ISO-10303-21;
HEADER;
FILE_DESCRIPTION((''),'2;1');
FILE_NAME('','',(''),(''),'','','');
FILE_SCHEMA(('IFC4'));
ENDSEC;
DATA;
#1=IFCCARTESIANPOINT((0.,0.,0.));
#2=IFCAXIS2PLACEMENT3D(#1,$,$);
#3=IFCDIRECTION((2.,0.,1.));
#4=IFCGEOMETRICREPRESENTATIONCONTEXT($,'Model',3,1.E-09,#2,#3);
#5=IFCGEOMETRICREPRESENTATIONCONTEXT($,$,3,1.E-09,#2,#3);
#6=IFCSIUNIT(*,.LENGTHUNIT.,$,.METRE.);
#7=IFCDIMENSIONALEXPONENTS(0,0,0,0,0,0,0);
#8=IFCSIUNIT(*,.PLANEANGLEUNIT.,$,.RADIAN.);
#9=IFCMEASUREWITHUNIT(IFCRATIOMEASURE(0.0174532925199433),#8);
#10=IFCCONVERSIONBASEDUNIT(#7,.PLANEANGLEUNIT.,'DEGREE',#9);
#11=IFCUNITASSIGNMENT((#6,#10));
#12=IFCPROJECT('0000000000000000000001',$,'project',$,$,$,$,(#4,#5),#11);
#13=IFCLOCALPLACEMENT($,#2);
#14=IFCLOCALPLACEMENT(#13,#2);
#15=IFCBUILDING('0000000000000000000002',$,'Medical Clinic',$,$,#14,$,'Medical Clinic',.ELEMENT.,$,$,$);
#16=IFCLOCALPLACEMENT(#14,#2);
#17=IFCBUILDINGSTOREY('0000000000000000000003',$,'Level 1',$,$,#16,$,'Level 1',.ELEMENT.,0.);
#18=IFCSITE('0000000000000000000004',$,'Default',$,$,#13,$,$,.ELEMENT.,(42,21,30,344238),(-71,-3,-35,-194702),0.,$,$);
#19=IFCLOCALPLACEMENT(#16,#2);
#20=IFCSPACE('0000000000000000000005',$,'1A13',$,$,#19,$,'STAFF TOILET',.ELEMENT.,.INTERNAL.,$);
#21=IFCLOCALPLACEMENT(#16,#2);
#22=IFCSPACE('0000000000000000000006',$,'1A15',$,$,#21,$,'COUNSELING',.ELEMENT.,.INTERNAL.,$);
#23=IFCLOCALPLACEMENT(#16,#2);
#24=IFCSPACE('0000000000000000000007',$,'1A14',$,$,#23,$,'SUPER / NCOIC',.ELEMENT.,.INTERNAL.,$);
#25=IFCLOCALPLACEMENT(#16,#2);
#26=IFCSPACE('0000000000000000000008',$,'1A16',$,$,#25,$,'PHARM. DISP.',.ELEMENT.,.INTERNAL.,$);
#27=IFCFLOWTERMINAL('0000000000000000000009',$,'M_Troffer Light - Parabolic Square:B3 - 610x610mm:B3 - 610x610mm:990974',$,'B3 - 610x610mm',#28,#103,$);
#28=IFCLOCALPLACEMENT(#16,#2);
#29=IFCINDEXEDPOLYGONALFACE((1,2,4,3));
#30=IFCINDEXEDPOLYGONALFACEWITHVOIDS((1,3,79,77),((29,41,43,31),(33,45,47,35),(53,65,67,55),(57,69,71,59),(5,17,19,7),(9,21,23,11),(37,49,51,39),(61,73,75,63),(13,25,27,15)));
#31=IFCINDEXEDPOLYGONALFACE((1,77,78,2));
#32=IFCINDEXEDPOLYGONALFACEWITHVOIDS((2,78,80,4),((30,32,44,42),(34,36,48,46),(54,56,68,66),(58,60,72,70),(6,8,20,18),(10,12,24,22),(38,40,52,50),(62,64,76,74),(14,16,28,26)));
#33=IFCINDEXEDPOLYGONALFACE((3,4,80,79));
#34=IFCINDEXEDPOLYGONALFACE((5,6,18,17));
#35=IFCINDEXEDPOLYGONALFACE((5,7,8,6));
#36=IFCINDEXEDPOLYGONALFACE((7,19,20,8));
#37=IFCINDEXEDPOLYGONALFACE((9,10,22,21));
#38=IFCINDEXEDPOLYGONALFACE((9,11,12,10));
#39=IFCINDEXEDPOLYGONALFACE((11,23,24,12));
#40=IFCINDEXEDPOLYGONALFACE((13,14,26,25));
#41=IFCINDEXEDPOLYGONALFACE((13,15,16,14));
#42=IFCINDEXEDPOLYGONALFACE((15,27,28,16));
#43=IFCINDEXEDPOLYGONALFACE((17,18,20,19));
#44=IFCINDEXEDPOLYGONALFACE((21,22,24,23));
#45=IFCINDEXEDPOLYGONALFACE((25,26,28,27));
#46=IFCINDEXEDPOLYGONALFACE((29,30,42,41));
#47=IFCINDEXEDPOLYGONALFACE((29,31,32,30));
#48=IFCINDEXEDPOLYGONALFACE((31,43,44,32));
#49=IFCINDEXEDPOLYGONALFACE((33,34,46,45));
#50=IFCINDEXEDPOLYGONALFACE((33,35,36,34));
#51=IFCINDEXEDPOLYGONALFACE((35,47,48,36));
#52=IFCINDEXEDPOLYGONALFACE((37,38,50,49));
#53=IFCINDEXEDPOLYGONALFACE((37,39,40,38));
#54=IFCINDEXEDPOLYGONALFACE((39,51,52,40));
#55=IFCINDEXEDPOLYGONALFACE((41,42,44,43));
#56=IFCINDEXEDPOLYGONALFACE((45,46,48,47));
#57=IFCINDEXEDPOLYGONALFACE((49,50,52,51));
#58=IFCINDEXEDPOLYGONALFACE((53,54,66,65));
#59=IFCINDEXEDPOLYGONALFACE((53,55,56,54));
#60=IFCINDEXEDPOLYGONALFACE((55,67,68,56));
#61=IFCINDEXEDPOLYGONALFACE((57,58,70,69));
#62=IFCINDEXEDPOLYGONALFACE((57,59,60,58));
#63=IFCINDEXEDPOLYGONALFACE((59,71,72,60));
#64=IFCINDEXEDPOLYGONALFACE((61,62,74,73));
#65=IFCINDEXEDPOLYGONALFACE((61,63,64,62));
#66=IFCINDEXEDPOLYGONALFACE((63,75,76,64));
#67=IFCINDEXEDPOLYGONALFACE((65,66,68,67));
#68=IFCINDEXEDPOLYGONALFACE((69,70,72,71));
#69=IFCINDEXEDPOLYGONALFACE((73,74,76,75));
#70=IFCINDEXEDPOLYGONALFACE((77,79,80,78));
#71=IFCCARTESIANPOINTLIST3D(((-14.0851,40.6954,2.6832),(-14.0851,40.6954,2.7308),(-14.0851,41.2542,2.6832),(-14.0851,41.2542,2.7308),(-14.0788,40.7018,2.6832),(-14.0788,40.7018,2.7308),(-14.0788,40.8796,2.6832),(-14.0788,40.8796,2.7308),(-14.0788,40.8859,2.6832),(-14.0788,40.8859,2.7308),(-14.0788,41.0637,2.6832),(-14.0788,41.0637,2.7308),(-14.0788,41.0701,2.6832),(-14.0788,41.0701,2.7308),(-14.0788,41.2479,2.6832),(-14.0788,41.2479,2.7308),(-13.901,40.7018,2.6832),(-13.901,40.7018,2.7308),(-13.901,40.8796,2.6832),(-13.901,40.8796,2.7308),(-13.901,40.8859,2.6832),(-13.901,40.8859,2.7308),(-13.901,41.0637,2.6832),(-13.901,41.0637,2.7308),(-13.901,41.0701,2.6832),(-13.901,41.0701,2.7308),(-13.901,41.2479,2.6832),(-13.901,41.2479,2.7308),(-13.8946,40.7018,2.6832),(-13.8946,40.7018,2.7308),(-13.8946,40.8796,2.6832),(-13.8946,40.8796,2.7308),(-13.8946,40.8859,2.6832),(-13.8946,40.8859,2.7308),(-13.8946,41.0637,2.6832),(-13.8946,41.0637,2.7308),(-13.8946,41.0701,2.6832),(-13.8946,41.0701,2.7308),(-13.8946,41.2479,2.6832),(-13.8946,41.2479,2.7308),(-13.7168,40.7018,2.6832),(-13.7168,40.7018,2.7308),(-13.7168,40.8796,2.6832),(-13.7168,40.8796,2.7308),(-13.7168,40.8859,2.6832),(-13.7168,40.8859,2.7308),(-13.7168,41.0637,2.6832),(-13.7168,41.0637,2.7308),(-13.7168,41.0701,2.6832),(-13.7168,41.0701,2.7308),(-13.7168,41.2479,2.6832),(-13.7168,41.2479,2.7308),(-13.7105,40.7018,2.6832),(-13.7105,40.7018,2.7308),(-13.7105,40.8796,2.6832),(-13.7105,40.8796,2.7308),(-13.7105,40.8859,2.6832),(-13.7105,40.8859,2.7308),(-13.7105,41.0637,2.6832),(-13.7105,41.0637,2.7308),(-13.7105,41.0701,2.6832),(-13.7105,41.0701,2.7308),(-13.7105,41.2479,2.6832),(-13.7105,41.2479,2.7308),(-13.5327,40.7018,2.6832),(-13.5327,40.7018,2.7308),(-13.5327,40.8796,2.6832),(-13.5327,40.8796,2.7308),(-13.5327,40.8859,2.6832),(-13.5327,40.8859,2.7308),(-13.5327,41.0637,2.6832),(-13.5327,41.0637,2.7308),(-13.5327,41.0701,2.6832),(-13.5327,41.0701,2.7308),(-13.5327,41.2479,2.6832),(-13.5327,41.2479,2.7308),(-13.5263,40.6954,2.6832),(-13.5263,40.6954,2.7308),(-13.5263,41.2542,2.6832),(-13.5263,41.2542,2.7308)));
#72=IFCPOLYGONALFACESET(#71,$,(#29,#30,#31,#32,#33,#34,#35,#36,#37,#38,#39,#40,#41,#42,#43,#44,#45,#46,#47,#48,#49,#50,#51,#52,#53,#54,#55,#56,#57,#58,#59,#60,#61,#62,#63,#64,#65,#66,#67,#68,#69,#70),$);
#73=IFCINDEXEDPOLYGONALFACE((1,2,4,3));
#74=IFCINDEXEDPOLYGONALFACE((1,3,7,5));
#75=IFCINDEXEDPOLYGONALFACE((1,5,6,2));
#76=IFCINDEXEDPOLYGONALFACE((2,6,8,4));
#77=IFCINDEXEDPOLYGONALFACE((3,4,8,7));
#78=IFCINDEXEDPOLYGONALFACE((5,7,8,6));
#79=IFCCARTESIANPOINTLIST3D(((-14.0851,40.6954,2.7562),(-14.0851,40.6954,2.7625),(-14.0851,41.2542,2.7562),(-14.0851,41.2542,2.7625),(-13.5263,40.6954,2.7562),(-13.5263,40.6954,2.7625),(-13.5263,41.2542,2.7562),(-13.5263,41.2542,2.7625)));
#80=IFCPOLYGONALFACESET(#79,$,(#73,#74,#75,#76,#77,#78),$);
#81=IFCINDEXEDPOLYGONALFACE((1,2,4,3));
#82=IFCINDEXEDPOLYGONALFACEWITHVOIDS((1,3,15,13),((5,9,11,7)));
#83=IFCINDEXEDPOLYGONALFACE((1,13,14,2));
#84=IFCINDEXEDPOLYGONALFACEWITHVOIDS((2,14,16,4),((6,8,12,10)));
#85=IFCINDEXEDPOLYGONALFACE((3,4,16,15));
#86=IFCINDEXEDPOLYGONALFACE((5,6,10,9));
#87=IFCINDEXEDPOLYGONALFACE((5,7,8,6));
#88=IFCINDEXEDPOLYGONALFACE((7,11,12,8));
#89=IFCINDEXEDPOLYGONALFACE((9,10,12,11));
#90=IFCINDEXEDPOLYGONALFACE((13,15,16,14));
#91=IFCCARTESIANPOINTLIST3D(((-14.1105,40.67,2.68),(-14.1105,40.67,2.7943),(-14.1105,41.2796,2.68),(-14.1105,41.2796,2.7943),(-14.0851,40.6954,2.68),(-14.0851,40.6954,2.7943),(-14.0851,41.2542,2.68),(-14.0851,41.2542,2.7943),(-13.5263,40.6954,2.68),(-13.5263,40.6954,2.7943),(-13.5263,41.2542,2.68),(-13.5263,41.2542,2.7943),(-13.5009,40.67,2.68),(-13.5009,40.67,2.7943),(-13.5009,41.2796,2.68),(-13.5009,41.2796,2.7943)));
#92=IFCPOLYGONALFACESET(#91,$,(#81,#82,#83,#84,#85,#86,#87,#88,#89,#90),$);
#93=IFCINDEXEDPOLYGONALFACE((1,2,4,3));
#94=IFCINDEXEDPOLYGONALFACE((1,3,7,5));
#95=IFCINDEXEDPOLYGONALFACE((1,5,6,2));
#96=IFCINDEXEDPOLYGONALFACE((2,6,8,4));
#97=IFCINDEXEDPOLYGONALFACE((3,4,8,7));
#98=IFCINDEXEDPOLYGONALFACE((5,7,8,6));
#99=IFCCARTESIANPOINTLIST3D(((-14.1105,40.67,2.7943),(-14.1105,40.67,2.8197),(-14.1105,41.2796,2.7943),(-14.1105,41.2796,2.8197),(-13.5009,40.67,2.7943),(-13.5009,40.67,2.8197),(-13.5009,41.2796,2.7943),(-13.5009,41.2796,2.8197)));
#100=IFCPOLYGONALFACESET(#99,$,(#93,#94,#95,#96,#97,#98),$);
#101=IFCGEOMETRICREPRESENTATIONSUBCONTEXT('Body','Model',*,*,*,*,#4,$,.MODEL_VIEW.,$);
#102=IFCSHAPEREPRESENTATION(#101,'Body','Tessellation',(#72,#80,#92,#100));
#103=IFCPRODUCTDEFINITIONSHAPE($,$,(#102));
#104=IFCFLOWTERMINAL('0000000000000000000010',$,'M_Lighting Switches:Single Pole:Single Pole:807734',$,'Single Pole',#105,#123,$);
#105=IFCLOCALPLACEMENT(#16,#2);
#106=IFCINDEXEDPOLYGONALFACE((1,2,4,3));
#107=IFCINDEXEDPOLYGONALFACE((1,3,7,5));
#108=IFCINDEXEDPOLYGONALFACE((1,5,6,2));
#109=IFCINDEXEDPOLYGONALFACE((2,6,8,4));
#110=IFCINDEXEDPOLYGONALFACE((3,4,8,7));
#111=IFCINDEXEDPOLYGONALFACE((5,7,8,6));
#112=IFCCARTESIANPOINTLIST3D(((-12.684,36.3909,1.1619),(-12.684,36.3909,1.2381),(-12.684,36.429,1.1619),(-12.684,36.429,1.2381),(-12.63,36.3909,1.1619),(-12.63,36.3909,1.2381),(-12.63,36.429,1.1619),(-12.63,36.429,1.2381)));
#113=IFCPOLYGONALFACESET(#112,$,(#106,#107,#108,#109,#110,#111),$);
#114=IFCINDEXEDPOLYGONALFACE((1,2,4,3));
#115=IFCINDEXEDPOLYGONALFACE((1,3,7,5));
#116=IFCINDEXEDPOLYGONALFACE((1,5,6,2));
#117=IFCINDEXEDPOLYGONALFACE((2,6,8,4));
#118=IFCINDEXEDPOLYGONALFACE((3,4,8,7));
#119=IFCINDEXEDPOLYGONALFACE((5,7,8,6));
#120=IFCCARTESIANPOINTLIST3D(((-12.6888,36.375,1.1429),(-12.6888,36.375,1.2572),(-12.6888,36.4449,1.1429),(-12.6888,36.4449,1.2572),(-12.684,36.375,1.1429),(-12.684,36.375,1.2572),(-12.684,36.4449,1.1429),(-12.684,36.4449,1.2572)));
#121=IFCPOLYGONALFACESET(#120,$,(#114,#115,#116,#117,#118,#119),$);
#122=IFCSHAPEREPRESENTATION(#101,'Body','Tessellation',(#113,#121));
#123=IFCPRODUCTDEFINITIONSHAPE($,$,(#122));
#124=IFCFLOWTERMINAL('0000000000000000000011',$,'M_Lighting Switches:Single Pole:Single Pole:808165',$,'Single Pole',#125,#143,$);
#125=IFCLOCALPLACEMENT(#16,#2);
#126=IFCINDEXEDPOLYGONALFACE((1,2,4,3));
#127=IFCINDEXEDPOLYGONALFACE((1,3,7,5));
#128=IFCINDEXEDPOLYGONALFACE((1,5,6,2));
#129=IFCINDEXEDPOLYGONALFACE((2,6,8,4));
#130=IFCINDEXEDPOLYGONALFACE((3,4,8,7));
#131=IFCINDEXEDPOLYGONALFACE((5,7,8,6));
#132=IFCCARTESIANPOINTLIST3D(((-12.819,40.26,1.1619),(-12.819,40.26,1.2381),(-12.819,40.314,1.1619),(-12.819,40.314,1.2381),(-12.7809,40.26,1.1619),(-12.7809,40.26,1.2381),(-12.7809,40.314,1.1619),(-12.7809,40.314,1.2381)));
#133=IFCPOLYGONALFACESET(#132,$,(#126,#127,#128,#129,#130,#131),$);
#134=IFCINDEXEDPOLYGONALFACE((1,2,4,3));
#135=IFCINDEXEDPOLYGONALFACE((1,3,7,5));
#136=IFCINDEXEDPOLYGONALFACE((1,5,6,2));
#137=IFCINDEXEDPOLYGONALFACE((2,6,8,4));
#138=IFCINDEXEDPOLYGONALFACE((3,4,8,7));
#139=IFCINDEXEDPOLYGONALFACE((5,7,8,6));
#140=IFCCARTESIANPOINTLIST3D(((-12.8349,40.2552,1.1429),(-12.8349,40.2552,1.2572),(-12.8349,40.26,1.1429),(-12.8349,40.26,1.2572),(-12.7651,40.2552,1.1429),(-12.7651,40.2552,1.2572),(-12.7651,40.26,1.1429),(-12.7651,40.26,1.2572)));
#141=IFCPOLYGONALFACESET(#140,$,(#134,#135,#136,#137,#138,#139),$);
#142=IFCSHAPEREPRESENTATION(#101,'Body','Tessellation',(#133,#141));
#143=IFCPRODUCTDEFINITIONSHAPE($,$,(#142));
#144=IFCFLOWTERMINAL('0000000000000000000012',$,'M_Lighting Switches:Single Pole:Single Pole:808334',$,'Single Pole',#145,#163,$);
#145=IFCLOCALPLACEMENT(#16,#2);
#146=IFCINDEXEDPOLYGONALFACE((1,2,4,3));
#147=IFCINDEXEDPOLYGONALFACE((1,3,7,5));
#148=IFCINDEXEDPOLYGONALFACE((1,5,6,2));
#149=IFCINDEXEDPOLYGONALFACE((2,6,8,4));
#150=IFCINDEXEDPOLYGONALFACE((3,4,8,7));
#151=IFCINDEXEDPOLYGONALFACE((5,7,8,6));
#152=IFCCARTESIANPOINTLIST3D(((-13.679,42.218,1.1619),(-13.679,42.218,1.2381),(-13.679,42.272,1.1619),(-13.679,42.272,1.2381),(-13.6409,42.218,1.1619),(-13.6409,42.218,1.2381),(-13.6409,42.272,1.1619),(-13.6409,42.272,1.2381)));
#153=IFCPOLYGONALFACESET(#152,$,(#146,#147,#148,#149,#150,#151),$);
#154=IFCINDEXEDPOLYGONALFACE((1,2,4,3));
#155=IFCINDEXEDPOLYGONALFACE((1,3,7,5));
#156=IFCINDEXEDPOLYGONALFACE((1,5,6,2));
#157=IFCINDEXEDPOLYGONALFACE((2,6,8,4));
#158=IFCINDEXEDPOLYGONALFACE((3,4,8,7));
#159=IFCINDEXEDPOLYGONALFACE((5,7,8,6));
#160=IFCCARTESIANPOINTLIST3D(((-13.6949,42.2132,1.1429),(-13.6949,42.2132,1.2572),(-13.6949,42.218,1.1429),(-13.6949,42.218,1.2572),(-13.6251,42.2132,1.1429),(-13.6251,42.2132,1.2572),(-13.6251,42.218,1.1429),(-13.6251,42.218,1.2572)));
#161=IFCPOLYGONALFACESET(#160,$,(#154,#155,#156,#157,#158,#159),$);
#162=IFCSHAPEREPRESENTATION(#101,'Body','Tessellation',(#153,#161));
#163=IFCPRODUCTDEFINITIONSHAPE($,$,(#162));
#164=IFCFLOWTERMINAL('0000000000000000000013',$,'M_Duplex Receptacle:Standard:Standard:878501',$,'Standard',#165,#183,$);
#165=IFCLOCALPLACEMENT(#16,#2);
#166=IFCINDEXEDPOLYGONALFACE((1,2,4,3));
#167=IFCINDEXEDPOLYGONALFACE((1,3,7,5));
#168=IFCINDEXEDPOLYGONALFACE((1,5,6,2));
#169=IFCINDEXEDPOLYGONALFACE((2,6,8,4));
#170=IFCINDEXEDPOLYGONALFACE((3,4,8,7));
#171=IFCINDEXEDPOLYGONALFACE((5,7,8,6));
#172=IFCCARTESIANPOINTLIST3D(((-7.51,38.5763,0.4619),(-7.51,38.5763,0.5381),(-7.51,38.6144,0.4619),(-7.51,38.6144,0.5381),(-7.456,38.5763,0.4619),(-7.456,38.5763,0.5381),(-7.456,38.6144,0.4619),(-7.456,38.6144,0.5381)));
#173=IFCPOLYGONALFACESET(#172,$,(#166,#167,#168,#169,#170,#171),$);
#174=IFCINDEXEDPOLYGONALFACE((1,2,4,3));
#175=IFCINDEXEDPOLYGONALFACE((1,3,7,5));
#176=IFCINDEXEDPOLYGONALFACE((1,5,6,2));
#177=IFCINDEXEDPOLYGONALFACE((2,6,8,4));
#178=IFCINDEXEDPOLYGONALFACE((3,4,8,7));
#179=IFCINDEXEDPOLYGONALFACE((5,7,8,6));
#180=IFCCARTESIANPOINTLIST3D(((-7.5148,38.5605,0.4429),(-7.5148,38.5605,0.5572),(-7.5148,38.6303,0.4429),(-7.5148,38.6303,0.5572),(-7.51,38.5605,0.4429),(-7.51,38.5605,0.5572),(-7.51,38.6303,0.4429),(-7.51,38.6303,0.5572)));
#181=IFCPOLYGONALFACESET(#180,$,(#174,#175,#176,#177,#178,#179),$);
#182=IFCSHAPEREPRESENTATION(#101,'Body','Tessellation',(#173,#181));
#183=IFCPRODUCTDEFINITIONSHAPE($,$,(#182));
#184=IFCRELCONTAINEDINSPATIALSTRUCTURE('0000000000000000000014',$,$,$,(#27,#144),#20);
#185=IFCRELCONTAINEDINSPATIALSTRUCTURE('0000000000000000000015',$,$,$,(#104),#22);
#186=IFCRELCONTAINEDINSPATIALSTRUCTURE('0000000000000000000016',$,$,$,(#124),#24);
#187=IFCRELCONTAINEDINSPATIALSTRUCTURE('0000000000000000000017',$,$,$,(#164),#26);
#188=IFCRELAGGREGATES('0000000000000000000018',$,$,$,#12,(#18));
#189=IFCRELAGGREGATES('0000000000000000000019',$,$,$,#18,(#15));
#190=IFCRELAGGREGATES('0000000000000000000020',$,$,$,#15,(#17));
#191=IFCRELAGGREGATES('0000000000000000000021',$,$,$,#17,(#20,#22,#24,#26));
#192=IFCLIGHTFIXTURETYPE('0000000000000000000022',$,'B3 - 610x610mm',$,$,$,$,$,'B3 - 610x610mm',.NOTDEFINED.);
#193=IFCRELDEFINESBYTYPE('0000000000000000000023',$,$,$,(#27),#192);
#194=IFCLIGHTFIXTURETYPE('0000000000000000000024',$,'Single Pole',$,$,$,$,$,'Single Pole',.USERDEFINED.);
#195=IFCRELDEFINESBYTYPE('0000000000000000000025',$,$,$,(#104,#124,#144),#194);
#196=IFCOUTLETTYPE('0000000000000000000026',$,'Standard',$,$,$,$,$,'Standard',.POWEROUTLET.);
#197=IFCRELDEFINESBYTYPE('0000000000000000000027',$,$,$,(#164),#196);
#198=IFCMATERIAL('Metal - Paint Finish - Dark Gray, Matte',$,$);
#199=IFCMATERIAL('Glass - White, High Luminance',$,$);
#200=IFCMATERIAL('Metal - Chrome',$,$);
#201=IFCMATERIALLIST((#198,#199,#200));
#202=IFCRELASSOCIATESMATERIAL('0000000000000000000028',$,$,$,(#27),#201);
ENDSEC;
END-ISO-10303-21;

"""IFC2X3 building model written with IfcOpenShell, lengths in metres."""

from ifc_helpers import new_model, entity, si_unit, converted_unit, direction, frame, frame_2d, origin, origin_2d_with_axis, place, context, subcontext, project, spatial, polyline, rectangle, outline, extrude, source, transform, mapped, material, material_list, type_object, type_shapes, element, save


model = new_model("IFC2X3")

# Units and contexts
model_context = context("Model", 3, precision=1e-09, world=origin(), true_north=direction((2.0, 0.0, 1.0)))
context_of_model = context(None, 3, precision=1e-09, world=origin(), true_north=direction((2.0, 0.0, 1.0)))
body_context = subcontext(model_context, "Body", "Model", "MODEL_VIEW")
ifc_project = project(units=[si_unit("LENGTHUNIT", "METRE"), converted_unit("PLANEANGLEUNIT", "DEGREE", entity("IfcRatioMeasure", 0.0174532925199433), si_unit("PLANEANGLEUNIT", "RADIAN"), dimensions=[0, 0, 0, 0, 0, 0, 0])], contexts=[model_context, context_of_model])

# Site, building, storey, space
site_placement = place(None, origin())
site = spatial("IfcSite", under=ifc_project, at=site_placement, Name="Default", CompositionType="ELEMENT", RefLatitude=(42, 21, 30, 344238), RefLongitude=(-71, -3, -35, -194702), RefElevation=0.0)
building_placement = place(site_placement, origin())
building = spatial("IfcBuilding", under=site, at=building_placement, Name="Medical Clinic", LongName="Medical Clinic", CompositionType="ELEMENT")
storey_placement = place(building_placement, origin())
storey = spatial("IfcBuildingStorey", under=building, at=storey_placement, Name="Level 1", LongName="Level 1", CompositionType="ELEMENT", Elevation=0.0)
space_1_placement = place(storey_placement, origin())
space_1 = spatial("IfcSpace", under=storey, at=space_1_placement, Name="1A13", LongName="STAFF TOILET", CompositionType="ELEMENT", InteriorOrExteriorSpace="INTERNAL")

# Flow terminal
ifc_material_1 = material(Name="Metal - Paint Finish - Dark Gray, Matte")
ifc_material_2 = material(Name="Glass - White, High Luminance")
ifc_material_3 = material(Name="Metal - Chrome")
ifc_material_list = material_list([ifc_material_1, ifc_material_2, ifc_material_3])
light_fixture_type_1 = type_object("IfcLightFixtureType", Name="B3 - 610x610mm", ElementType="B3 - 610x610mm", PredefinedType="NOTDEFINED")
shared_shape_1 = source(origin(), body_context, "Body", "SweptSolid", [
    extrude(outline(polyline([(-0.2794, -0.2794), (0.2794, -0.2794), (0.2794, 0.2794), (-0.2794, 0.2794), (-0.2794, -0.2794)]), holes=[polyline([(-0.0952, 0.0953), (-0.273, 0.0953), (-0.273, 0.2731), (-0.0952, 0.2731), (-0.0952, 0.0953)]), polyline([(0.2731, 0.0953), (0.0953, 0.0953), (0.0953, 0.2731), (0.2731, 0.2731), (0.2731, 0.0953)]), polyline([(-0.0889, 0.2731), (0.0889, 0.2731), (0.0889, 0.0953), (-0.0889, 0.0953), (-0.0889, 0.2731)]), polyline([(0.2731, -0.273), (0.0953, -0.273), (0.0953, -0.0952), (0.2731, -0.0952), (0.2731, -0.273)]), polyline([(0.0889, -0.273), (-0.0889, -0.273), (-0.0889, -0.0952), (0.0889, -0.0952), (0.0889, -0.273)]), polyline([(-0.0952, -0.273), (-0.273, -0.273), (-0.273, -0.0952), (-0.0952, -0.0952), (-0.0952, -0.273)]), polyline([(-0.0952, -0.0889), (-0.273, -0.0889), (-0.273, 0.0889), (-0.0952, 0.0889), (-0.0952, -0.0889)]), polyline([(0.0889, -0.0889), (-0.0889, -0.0889), (-0.0889, 0.0889), (0.0889, 0.0889), (0.0889, -0.0889)]), polyline([(0.2731, -0.0889), (0.0953, -0.0889), (0.0953, 0.0889), (0.2731, 0.0889), (0.2731, -0.0889)])]), frame((0.0, -0.3048, -0.0508), z_axis=(0.0, 0.0, 1.0), x_axis=(-1.0, 0.0, 0.0)), (0.0, 0.0, 1.0), 0.0476),
    extrude(rectangle(XDim=0.5588, YDim=0.5588, at=origin_2d_with_axis()), frame((0.0, -0.3048, -0.0825), z_axis=(0.0, 0.0, 1.0), x_axis=(-1.0, 0.0, 0.0)), (0.0, 0.0, 1.0), 0.0064),
    extrude(outline(polyline([(-0.3048, -0.3048), (0.3048, -0.3048), (0.3048, 0.3048), (-0.3048, 0.3048), (-0.3048, -0.3048)]), holes=[polyline([(0.2794, 0.2794), (0.2794, -0.2794), (-0.2794, -0.2794), (-0.2794, 0.2794), (0.2794, 0.2794)])]), frame((0.0, -0.3048, -0.1143)), (0.0, 0.0, 1.0), 0.1143),
    extrude(rectangle(XDim=0.6096, YDim=0.6096, at=origin_2d_with_axis()), frame((0.0, -0.3048, -0.1397), z_axis=(0.0, 0.0, 1.0), x_axis=(-1.0, 0.0, 0.0)), (0.0, 0.0, 1.0), 0.0254),
])
type_shapes(light_fixture_type_1, [shared_shape_1])
flow_terminal_1_placement = place(space_1_placement, frame((-13.8057, 40.67, 2.68), z_axis=(0.0, 0.0, -1.0), x_axis=(1.0, 0.0, 0.0)))
element("IfcFlowTerminal", 1, at=flow_terminal_1_placement, inside=space_1, type_object=light_fixture_type_1, material=ifc_material_list, Name="M_Troffer Light - Parabolic Square:B3 - 610x610mm:B3 - 610x610mm:990974", ObjectType="B3 - 610x610mm", context=body_context, shape_type="MappedRepresentation", body=[
    mapped(shared_shape_1, transform((0.0, 0.0, 0.0), scale=1.0)),
])

# Shared definitions
space_2_placement = place(storey_placement, origin())
space_2 = spatial("IfcSpace", under=storey, at=space_2_placement, Name="1A15", LongName="COUNSELING", CompositionType="ELEMENT", InteriorOrExteriorSpace="INTERNAL")

# Flow terminal
light_fixture_type_2 = type_object("IfcLightFixtureType", Name="Single Pole", ElementType="Single Pole", PredefinedType="USERDEFINED")
shared_shape_2 = source(origin(), body_context, "Body", "SweptSolid", [
    extrude(rectangle(XDim=0.0381, YDim=0.0762, at=origin_2d_with_axis()), frame((0.0, 0.0, -0.054), z_axis=(0.0, 0.0, 1.0), x_axis=(-1.0, 0.0, 0.0)), (0.0, 0.0, 1.0), 0.054),
    extrude(rectangle(XDim=0.0698, YDim=0.1143, at=frame_2d((0.0, 0.0), x_axis=(1.0, 0.0))), frame((0.0, 0.0, 0.0), z_axis=(0.0, 0.0, 1.0), x_axis=(-1.0, 0.0, 0.0)), (0.0, 0.0, 1.0), 0.0048),
])
type_shapes(light_fixture_type_2, [shared_shape_2])
flow_terminal_2_placement = place(space_2_placement, frame((-12.684, 36.4099, 1.2), z_axis=(-1.0, 0.0, 0.0), x_axis=(0.0, -1.0, 0.0)))
element("IfcFlowTerminal", 2, at=flow_terminal_2_placement, inside=space_2, type_object=light_fixture_type_2, Name="M_Lighting Switches:Single Pole:Single Pole:807734", ObjectType="Single Pole", context=body_context, shape_type="MappedRepresentation", body=[
    mapped(shared_shape_2, transform((0.0, 0.0, 0.0), scale=1.0)),
])

# Shared definitions
space_3_placement = place(storey_placement, origin())
space_3 = spatial("IfcSpace", under=storey, at=space_3_placement, Name="1A14", LongName="SUPER / NCOIC", CompositionType="ELEMENT", InteriorOrExteriorSpace="INTERNAL")

# Flow terminals
flow_terminal_3_placement = place(space_3_placement, frame((-12.8, 40.26, 1.2), z_axis=(0.0, -1.0, 0.0), x_axis=(1.0, 0.0, 0.0)))
element("IfcFlowTerminal", 3, at=flow_terminal_3_placement, inside=space_3, type_object=light_fixture_type_2, Name="M_Lighting Switches:Single Pole:Single Pole:808165", ObjectType="Single Pole", context=body_context, shape_type="MappedRepresentation", body=[
    mapped(shared_shape_2, transform((0.0, 0.0, 0.0), scale=1.0)),
])
flow_terminal_4_placement = place(space_1_placement, frame((-13.66, 42.218, 1.2), z_axis=(0.0, -1.0, 0.0), x_axis=(1.0, 0.0, 0.0)))
element("IfcFlowTerminal", 4, at=flow_terminal_4_placement, inside=space_1, type_object=light_fixture_type_2, Name="M_Lighting Switches:Single Pole:Single Pole:808334", ObjectType="Single Pole", context=body_context, shape_type="MappedRepresentation", body=[
    mapped(shared_shape_2, transform((0.0, 0.0, 0.0), scale=1.0)),
])

# Shared definitions
space_4_placement = place(storey_placement, origin())
space_4 = spatial("IfcSpace", under=storey, at=space_4_placement, Name="1A16", LongName="PHARM. DISP.", CompositionType="ELEMENT", InteriorOrExteriorSpace="INTERNAL")

# Flow terminal
outlet_type = type_object("IfcOutletType", Name="Standard", ElementType="Standard", PredefinedType="POWEROUTLET")
shared_shape_3 = source(origin(), body_context, "Body", "SweptSolid", [
    extrude(rectangle(XDim=0.0381, YDim=0.0762, at=origin_2d_with_axis()), frame((0.0, 0.0, -0.054), z_axis=(0.0, 0.0, 1.0), x_axis=(-1.0, 0.0, 0.0)), (0.0, 0.0, 1.0), 0.054),
    extrude(rectangle(XDim=0.0698, YDim=0.1143, at=frame_2d((0.0, 0.0), x_axis=(1.0, 0.0))), frame((0.0, 0.0, 0.0), z_axis=(0.0, 0.0, 1.0), x_axis=(-1.0, 0.0, 0.0)), (0.0, 0.0, 1.0), 0.0048),
])
type_shapes(outlet_type, [shared_shape_3])
for number, where, z_axis, x_axis, name in (
    (5, (-7.51, 38.5954, 0.5), (-1.0, 0.0, 0.0), (0.0, -1.0, 0.0), "M_Duplex Receptacle:Standard:Standard:878501"),
):
    element("IfcFlowTerminal", number, at=place(space_4_placement, frame(where, z_axis=z_axis, x_axis=x_axis)), inside=space_4, type_object=outlet_type, Name=name, ObjectType="Standard", context=body_context, shape_type="MappedRepresentation", body=[
        mapped(shared_shape_3, transform((0.0, 0.0, 0.0), scale=1.0)),
    ])

save(model, "model.ifc")
